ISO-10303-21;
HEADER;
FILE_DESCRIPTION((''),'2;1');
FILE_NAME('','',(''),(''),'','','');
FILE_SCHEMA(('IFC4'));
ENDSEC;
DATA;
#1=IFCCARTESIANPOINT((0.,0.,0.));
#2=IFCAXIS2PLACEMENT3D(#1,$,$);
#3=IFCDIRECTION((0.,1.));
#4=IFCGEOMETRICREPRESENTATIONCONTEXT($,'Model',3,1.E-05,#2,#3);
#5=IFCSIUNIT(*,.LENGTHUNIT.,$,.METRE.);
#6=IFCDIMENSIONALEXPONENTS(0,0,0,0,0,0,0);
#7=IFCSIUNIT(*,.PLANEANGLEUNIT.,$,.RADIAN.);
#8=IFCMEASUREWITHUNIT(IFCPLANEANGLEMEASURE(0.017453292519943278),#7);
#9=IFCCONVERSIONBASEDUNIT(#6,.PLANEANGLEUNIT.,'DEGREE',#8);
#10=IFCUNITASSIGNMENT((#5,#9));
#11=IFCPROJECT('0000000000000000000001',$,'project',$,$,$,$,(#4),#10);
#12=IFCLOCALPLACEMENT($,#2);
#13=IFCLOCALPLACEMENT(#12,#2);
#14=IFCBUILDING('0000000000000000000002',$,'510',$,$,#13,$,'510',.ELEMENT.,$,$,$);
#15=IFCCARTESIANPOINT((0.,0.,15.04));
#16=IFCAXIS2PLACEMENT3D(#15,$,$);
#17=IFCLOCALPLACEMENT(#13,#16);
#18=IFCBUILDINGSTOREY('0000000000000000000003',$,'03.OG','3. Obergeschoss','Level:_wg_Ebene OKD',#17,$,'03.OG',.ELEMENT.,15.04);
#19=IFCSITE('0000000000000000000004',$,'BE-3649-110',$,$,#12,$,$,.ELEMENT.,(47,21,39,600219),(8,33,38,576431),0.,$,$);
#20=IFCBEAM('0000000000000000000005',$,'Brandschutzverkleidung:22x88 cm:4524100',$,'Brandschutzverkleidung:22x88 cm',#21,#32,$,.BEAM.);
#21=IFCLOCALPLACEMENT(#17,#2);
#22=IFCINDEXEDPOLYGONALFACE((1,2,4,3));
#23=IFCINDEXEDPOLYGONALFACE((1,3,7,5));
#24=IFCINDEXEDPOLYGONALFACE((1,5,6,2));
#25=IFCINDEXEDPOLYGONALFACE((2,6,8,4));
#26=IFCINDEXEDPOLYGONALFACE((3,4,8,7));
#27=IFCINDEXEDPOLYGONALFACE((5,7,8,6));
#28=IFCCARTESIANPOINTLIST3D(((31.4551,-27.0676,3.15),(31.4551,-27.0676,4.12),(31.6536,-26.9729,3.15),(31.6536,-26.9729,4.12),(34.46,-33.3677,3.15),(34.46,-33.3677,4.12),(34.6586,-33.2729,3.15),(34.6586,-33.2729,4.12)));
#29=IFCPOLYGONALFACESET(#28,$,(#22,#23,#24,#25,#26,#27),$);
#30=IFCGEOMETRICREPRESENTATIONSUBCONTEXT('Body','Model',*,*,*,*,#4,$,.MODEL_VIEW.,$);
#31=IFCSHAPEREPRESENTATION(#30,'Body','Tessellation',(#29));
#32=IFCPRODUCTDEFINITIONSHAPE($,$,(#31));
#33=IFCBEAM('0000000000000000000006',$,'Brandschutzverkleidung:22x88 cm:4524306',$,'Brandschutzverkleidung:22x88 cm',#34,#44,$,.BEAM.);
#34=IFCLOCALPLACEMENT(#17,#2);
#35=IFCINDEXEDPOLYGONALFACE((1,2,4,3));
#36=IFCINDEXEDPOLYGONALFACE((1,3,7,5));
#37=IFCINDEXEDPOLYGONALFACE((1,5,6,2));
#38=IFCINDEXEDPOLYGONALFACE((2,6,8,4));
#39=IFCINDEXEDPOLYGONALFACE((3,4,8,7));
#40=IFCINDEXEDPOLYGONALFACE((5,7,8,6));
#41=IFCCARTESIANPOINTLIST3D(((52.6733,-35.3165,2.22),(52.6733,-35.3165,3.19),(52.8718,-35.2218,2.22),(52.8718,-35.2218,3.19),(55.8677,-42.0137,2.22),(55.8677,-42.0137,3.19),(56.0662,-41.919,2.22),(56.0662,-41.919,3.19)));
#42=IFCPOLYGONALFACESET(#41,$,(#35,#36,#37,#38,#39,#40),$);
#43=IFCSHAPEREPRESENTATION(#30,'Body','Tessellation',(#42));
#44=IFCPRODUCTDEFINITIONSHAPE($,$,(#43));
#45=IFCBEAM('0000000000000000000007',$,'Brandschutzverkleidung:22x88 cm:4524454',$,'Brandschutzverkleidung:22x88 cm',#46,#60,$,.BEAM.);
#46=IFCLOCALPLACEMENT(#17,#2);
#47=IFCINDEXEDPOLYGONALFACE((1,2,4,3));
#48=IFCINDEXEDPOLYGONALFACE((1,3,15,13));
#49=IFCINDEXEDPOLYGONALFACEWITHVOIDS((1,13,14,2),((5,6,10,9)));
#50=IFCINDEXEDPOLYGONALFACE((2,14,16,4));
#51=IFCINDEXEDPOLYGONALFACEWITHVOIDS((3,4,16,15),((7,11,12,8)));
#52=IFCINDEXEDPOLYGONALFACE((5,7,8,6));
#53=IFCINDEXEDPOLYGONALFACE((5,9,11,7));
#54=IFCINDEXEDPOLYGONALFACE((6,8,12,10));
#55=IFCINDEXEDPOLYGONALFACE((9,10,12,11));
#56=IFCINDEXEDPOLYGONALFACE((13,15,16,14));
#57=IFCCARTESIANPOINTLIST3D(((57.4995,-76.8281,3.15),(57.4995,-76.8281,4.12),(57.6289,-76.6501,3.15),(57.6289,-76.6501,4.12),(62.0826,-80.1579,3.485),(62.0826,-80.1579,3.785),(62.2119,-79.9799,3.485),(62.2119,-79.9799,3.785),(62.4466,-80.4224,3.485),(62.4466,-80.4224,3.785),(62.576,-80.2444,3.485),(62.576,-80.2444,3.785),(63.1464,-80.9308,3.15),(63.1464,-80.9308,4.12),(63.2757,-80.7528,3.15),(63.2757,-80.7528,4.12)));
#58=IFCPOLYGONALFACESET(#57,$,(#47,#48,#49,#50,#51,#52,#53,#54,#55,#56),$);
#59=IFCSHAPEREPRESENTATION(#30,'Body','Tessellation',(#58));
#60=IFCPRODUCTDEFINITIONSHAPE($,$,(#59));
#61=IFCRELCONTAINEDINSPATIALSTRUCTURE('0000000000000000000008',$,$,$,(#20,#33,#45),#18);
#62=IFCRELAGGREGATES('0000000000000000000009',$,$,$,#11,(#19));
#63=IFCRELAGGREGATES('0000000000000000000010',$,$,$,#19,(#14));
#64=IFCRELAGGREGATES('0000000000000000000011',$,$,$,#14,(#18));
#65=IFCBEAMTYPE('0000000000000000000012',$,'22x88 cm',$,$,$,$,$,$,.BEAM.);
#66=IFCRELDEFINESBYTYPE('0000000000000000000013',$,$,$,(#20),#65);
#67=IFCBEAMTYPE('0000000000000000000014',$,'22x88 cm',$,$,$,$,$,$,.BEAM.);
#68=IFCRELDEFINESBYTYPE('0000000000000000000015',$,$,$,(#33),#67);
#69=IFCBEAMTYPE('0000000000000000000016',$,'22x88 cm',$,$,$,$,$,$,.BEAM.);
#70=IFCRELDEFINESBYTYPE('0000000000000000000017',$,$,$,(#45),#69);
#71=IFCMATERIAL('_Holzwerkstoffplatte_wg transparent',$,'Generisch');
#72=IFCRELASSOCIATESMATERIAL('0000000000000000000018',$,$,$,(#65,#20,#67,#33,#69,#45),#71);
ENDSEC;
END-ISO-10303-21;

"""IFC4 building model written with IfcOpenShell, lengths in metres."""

from ifc_helpers import new_model, entity, si_unit, converted_unit, direction, frame, origin, place, context, subcontext, project, spatial, indexed_curve, outline, extrude, source, transform, mapped, material, type_object, type_shapes, element, save


model = new_model("IFC4")

# Units and contexts
model_context = context("Model", 3, precision=1e-05, world=origin(), true_north=direction((0.0, 1.0)))
body_context = subcontext(model_context, "Body", "Model", "MODEL_VIEW")
ifc_project = project(units=[si_unit("LENGTHUNIT", "METRE"), converted_unit("PLANEANGLEUNIT", "DEGREE", entity("IfcPlaneAngleMeasure", 0.017453292519943278), si_unit("PLANEANGLEUNIT", "RADIAN"), dimensions=[0, 0, 0, 0, 0, 0, 0])], contexts=[model_context])

# Site, building, storey
site_placement = place(None, origin())
site = spatial("IfcSite", under=ifc_project, at=site_placement, Name="BE-3649-110", CompositionType="ELEMENT", RefLatitude=(47, 21, 39, 600219), RefLongitude=(8, 33, 38, 576431), RefElevation=0.0)
building_placement = place(site_placement, origin())
building = spatial("IfcBuilding", under=site, at=building_placement, Name="510", LongName="510", CompositionType="ELEMENT")
storey_placement = place(building_placement, frame((0.0, 0.0, 15.04)))
storey = spatial("IfcBuildingStorey", under=building, at=storey_placement, Name="03.OG", Description="3. Obergeschoss", ObjectType="Level:_wg_Ebene OKD", LongName="03.OG", CompositionType="ELEMENT", Elevation=15.04)

# Beams
ifc_material_1 = material(Name="_Holzwerkstoffplatte_wg transparent", Category="Generisch")
beam_type_1 = type_object("IfcBeamType", Name="22x88 cm", PredefinedType="BEAM", material=ifc_material_1)
shared_shape_1 = source(origin(), body_context, "Body", "SweptSolid", [
    extrude(outline(indexed_curve([(-3.49, -0.11), (3.49, -0.11), (3.49, 0.11), (-3.49, 0.11), (-3.49, -0.11)], self_intersect=False)), frame((33.0568, -30.1703, -0.485), z_axis=(0.0, 0.0, 1.0), x_axis=(0.430511, -0.902585, 0.0)), (0.0, 0.0, 1.0), 0.97),
])
type_shapes(beam_type_1, [shared_shape_1])
beam_1_placement = place(storey_placement, frame((0.0, 0.0, 3.635)))
element("IfcBeam", 1, at=beam_1_placement, inside=storey, type_object=beam_type_1, material=ifc_material_1, Name="Brandschutzverkleidung:22x88 cm:4524100", ObjectType="Brandschutzverkleidung:22x88 cm", PredefinedType="BEAM", context=body_context, shape_type="MappedRepresentation", body=[
    mapped(shared_shape_1, transform((0.0, 0.0, 0.0), scale=1.0)),
])
beam_type_2 = type_object("IfcBeamType", Name="22x88 cm", PredefinedType="BEAM", material=ifc_material_1)
shared_shape_2 = source(origin(), body_context, "Body", "SweptSolid", [
    extrude(outline(indexed_curve([(-3.71, -0.11), (3.71, -0.11), (3.71, 0.11), (-3.71, 0.11), (-3.71, -0.11)], self_intersect=False)), frame((54.3698, -38.6177, -0.485), z_axis=(0.0, 0.0, 1.0), x_axis=(0.430511, -0.902585, 0.0)), (0.0, 0.0, 1.0), 0.97),
])
type_shapes(beam_type_2, [shared_shape_2])
beam_2_placement = place(storey_placement, frame((0.0, 0.0, 2.705)))
element("IfcBeam", 2, at=beam_2_placement, inside=storey, type_object=beam_type_2, material=ifc_material_1, Name="Brandschutzverkleidung:22x88 cm:4524306", ObjectType="Brandschutzverkleidung:22x88 cm", PredefinedType="BEAM", context=body_context, shape_type="MappedRepresentation", body=[
    mapped(shared_shape_2, transform((0.0, 0.0, 0.0), scale=1.0)),
])
beam_type_3 = type_object("IfcBeamType", Name="22x88 cm", PredefinedType="BEAM", material=ifc_material_1)
shared_shape_3 = source(origin(), body_context, "Body", "SweptSolid", [
    extrude(outline(indexed_curve([(-3.4899, -0.485), (3.49, -0.485), (3.49, 0.485), (-3.4899, 0.485), (-3.4899, -0.485)], self_intersect=False), holes=[indexed_curve([(2.175, -0.15), (2.175, 0.15), (2.625, 0.15), (2.625, -0.15), (2.175, -0.15)], self_intersect=False)]), frame((60.323, -78.8795, 0.0), z_axis=(0.587785, 0.809017, 0.0), x_axis=(0.809017, -0.587785, 0.0)), (0.0, 0.0, 1.0), 0.22),
])
type_shapes(beam_type_3, [shared_shape_3])
beam_3_placement = place(storey_placement, frame((0.0, 0.0, 3.635)))
element("IfcBeam", 3, at=beam_3_placement, inside=storey, type_object=beam_type_3, material=ifc_material_1, Name="Brandschutzverkleidung:22x88 cm:4524454", ObjectType="Brandschutzverkleidung:22x88 cm", PredefinedType="BEAM", context=body_context, shape_type="MappedRepresentation", body=[
    mapped(shared_shape_3, transform((0.0, 0.0, 0.0), scale=1.0)),
])

save(model, "model.ifc")
